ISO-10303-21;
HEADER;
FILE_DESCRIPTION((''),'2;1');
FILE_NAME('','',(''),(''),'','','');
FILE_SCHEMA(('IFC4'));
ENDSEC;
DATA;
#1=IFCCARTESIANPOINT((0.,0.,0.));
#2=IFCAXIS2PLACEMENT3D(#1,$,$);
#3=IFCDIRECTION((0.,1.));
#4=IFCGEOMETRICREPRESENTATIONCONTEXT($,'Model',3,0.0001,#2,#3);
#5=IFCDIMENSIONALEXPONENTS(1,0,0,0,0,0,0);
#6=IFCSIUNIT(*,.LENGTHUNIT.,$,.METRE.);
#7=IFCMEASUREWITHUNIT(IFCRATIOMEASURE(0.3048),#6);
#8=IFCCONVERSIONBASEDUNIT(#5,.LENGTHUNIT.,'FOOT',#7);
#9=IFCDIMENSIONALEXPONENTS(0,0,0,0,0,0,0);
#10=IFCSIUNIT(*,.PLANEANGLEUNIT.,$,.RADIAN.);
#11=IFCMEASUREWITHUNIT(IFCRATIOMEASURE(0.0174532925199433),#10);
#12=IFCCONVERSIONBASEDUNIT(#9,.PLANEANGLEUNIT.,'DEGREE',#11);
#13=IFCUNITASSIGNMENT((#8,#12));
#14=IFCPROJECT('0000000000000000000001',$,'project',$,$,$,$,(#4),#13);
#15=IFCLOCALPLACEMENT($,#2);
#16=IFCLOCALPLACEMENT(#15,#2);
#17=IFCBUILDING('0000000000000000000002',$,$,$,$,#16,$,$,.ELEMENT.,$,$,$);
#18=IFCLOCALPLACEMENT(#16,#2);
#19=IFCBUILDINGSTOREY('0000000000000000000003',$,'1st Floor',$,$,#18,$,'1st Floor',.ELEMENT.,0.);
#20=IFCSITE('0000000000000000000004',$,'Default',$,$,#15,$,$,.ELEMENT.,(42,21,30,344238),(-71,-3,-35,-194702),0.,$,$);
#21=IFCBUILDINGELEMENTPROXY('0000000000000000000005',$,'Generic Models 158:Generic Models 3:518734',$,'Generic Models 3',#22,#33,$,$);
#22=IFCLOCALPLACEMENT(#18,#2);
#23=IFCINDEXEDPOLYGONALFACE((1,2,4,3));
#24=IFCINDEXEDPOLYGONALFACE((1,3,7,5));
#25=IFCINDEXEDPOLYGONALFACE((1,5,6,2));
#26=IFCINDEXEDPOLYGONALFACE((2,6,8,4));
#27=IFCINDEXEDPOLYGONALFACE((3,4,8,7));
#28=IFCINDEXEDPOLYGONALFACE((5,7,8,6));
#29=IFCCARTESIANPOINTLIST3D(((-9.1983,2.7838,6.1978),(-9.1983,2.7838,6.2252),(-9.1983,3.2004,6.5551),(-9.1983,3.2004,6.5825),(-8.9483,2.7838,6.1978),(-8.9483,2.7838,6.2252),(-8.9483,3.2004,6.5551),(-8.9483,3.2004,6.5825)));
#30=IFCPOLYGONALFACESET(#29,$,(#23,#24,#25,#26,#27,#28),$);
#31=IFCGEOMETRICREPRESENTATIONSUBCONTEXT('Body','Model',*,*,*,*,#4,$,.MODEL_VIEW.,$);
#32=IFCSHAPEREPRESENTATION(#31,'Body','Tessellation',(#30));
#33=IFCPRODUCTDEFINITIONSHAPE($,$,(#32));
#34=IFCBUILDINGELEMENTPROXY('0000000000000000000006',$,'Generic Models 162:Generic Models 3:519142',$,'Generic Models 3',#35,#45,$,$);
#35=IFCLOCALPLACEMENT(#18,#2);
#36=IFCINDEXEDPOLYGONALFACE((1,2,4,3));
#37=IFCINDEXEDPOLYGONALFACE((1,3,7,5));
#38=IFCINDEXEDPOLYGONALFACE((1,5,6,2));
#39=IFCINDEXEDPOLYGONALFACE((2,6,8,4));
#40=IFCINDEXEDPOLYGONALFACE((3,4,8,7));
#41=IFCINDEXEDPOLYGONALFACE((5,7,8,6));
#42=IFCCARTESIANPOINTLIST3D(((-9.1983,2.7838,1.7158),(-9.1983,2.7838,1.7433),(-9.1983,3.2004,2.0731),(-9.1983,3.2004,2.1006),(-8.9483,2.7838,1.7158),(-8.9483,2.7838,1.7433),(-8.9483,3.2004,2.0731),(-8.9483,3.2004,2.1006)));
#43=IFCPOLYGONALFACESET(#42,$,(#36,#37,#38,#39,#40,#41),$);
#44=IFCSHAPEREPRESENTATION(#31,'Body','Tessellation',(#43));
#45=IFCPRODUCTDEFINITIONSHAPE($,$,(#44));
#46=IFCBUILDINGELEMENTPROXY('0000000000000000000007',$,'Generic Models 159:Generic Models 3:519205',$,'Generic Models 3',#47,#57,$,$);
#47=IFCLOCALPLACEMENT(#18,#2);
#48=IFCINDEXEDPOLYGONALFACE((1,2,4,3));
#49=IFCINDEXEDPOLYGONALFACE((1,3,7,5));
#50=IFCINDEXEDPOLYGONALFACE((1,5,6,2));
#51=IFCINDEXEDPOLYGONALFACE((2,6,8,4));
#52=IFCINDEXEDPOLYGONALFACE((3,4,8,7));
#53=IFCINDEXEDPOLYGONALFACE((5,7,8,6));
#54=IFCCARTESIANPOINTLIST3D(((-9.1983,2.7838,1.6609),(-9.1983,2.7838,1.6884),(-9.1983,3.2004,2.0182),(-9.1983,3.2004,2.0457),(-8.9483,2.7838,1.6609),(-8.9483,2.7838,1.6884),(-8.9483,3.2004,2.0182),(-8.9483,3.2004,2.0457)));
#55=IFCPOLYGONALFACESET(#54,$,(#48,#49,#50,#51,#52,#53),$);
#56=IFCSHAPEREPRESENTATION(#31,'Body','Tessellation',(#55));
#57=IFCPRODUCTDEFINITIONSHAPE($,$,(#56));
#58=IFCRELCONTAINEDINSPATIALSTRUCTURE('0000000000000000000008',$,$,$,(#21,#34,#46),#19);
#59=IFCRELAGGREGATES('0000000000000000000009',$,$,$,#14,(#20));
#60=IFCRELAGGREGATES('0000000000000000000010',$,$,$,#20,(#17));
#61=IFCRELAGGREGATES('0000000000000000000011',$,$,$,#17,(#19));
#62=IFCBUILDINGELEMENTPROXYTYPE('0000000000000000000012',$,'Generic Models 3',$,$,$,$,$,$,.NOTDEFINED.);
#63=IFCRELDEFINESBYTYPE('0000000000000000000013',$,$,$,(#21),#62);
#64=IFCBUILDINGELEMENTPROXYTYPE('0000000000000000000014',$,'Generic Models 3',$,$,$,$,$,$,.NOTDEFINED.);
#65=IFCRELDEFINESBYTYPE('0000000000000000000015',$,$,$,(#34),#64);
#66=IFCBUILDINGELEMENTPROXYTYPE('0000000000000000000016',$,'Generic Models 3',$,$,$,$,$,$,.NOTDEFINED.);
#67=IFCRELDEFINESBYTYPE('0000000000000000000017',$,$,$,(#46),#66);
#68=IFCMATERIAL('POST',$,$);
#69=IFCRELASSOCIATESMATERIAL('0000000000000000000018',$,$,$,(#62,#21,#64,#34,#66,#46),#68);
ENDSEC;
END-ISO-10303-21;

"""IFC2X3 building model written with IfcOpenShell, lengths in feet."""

from ifc_helpers import new_model, entity, si_unit, converted_unit, direction, frame, origin, place, context, subcontext, project, spatial, polyline, outline, extrude, source, transform, mapped, material, type_object, type_shapes, element, save


model = new_model("IFC2X3")

# Units and contexts
model_context = context("Model", 3, precision=0.0001, world=origin(), true_north=direction((0.0, 1.0)))
body_context = subcontext(model_context, "Body", "Model", "MODEL_VIEW")
ifc_project = project(units=[converted_unit("LENGTHUNIT", "FOOT", entity("IfcRatioMeasure", 0.3048), si_unit("LENGTHUNIT", "METRE"), dimensions=[1, 0, 0, 0, 0, 0, 0]), converted_unit("PLANEANGLEUNIT", "DEGREE", entity("IfcRatioMeasure", 0.0174532925199433), si_unit("PLANEANGLEUNIT", "RADIAN"), dimensions=[0, 0, 0, 0, 0, 0, 0])], contexts=[model_context])

# Site, building, storey
site_placement = place(None, origin())
site = spatial("IfcSite", under=ifc_project, at=site_placement, Name="Default", CompositionType="ELEMENT", RefLatitude=(42, 21, 30, 344238), RefLongitude=(-71, -3, -35, -194702), RefElevation=0.0)
building_placement = place(site_placement, origin())
building = spatial("IfcBuilding", under=site, at=building_placement, CompositionType="ELEMENT")
storey_placement = place(building_placement, origin())
storey = spatial("IfcBuildingStorey", under=building, at=storey_placement, Name="1st Floor", LongName="1st Floor", CompositionType="ELEMENT", Elevation=0.0)

# Building element proxies
ifc_material_1 = material(Name="POST")
building_element_proxy_type_1 = type_object("IfcBuildingElementProxyType", Name="Generic Models 3", PredefinedType="NOTDEFINED", material=ifc_material_1)
shared_shape_1 = source(origin(), body_context, "Body", "SweptSolid", [
    extrude(outline(polyline([(-0.2834, -0.0104), (0.2655, -0.0104), (0.2834, 0.0104), (-0.2655, 0.0104), (-0.2834, -0.0104)])), frame((-9.0421, 2.9921, 6.3902), z_axis=(1.0, 0.0, 0.0), x_axis=(0.0, -0.759118, -0.650953)), (0.0, 0.0, 1.0), 0.25),
])
type_shapes(building_element_proxy_type_1, [shared_shape_1])
proxy_1_placement = place(storey_placement, frame((-0.1562, 0.0, 0.0)))
element("IfcBuildingElementProxy", 1, at=proxy_1_placement, inside=storey, type_object=building_element_proxy_type_1, material=ifc_material_1, Name="Generic Models 158:Generic Models 3:518734", ObjectType="Generic Models 3", context=body_context, shape_type="MappedRepresentation", body=[
    mapped(shared_shape_1, transform((0.0, 0.0, 0.0), scale=1.0)),
])
building_element_proxy_type_2 = type_object("IfcBuildingElementProxyType", Name="Generic Models 3", PredefinedType="NOTDEFINED", material=ifc_material_1)
shared_shape_2 = source(origin(), body_context, "Body", "SweptSolid", [
    extrude(outline(polyline([(-0.2834, -0.0104), (0.2655, -0.0104), (0.2834, 0.0104), (-0.2655, 0.0104), (-0.2834, -0.0104)])), frame((-9.0421, 2.9921, 6.3902), z_axis=(1.0, 0.0, 0.0), x_axis=(0.0, -0.759118, -0.650953)), (0.0, 0.0, 1.0), 0.25),
])
type_shapes(building_element_proxy_type_2, [shared_shape_2])
proxy_2_placement = place(storey_placement, frame((-0.1562, 0.0, -4.482)))
element("IfcBuildingElementProxy", 2, at=proxy_2_placement, inside=storey, type_object=building_element_proxy_type_2, material=ifc_material_1, Name="Generic Models 162:Generic Models 3:519142", ObjectType="Generic Models 3", context=body_context, shape_type="MappedRepresentation", body=[
    mapped(shared_shape_2, transform((0.0, 0.0, 0.0), scale=1.0)),
])
building_element_proxy_type_3 = type_object("IfcBuildingElementProxyType", Name="Generic Models 3", PredefinedType="NOTDEFINED", material=ifc_material_1)
shared_shape_3 = source(origin(), body_context, "Body", "SweptSolid", [
    extrude(outline(polyline([(-0.2834, -0.0104), (0.2655, -0.0104), (0.2834, 0.0104), (-0.2655, 0.0104), (-0.2834, -0.0104)])), frame((-9.0421, 2.9921, 6.3902), z_axis=(1.0, 0.0, 0.0), x_axis=(0.0, -0.759118, -0.650953)), (0.0, 0.0, 1.0), 0.25),
])
type_shapes(building_element_proxy_type_3, [shared_shape_3])
proxy_3_placement = place(storey_placement, frame((-0.1562, 0.0, -4.5369)))
element("IfcBuildingElementProxy", 3, at=proxy_3_placement, inside=storey, type_object=building_element_proxy_type_3, material=ifc_material_1, Name="Generic Models 159:Generic Models 3:519205", ObjectType="Generic Models 3", context=body_context, shape_type="MappedRepresentation", body=[
    mapped(shared_shape_3, transform((0.0, 0.0, 0.0), scale=1.0)),
])

save(model, "model.ifc")
